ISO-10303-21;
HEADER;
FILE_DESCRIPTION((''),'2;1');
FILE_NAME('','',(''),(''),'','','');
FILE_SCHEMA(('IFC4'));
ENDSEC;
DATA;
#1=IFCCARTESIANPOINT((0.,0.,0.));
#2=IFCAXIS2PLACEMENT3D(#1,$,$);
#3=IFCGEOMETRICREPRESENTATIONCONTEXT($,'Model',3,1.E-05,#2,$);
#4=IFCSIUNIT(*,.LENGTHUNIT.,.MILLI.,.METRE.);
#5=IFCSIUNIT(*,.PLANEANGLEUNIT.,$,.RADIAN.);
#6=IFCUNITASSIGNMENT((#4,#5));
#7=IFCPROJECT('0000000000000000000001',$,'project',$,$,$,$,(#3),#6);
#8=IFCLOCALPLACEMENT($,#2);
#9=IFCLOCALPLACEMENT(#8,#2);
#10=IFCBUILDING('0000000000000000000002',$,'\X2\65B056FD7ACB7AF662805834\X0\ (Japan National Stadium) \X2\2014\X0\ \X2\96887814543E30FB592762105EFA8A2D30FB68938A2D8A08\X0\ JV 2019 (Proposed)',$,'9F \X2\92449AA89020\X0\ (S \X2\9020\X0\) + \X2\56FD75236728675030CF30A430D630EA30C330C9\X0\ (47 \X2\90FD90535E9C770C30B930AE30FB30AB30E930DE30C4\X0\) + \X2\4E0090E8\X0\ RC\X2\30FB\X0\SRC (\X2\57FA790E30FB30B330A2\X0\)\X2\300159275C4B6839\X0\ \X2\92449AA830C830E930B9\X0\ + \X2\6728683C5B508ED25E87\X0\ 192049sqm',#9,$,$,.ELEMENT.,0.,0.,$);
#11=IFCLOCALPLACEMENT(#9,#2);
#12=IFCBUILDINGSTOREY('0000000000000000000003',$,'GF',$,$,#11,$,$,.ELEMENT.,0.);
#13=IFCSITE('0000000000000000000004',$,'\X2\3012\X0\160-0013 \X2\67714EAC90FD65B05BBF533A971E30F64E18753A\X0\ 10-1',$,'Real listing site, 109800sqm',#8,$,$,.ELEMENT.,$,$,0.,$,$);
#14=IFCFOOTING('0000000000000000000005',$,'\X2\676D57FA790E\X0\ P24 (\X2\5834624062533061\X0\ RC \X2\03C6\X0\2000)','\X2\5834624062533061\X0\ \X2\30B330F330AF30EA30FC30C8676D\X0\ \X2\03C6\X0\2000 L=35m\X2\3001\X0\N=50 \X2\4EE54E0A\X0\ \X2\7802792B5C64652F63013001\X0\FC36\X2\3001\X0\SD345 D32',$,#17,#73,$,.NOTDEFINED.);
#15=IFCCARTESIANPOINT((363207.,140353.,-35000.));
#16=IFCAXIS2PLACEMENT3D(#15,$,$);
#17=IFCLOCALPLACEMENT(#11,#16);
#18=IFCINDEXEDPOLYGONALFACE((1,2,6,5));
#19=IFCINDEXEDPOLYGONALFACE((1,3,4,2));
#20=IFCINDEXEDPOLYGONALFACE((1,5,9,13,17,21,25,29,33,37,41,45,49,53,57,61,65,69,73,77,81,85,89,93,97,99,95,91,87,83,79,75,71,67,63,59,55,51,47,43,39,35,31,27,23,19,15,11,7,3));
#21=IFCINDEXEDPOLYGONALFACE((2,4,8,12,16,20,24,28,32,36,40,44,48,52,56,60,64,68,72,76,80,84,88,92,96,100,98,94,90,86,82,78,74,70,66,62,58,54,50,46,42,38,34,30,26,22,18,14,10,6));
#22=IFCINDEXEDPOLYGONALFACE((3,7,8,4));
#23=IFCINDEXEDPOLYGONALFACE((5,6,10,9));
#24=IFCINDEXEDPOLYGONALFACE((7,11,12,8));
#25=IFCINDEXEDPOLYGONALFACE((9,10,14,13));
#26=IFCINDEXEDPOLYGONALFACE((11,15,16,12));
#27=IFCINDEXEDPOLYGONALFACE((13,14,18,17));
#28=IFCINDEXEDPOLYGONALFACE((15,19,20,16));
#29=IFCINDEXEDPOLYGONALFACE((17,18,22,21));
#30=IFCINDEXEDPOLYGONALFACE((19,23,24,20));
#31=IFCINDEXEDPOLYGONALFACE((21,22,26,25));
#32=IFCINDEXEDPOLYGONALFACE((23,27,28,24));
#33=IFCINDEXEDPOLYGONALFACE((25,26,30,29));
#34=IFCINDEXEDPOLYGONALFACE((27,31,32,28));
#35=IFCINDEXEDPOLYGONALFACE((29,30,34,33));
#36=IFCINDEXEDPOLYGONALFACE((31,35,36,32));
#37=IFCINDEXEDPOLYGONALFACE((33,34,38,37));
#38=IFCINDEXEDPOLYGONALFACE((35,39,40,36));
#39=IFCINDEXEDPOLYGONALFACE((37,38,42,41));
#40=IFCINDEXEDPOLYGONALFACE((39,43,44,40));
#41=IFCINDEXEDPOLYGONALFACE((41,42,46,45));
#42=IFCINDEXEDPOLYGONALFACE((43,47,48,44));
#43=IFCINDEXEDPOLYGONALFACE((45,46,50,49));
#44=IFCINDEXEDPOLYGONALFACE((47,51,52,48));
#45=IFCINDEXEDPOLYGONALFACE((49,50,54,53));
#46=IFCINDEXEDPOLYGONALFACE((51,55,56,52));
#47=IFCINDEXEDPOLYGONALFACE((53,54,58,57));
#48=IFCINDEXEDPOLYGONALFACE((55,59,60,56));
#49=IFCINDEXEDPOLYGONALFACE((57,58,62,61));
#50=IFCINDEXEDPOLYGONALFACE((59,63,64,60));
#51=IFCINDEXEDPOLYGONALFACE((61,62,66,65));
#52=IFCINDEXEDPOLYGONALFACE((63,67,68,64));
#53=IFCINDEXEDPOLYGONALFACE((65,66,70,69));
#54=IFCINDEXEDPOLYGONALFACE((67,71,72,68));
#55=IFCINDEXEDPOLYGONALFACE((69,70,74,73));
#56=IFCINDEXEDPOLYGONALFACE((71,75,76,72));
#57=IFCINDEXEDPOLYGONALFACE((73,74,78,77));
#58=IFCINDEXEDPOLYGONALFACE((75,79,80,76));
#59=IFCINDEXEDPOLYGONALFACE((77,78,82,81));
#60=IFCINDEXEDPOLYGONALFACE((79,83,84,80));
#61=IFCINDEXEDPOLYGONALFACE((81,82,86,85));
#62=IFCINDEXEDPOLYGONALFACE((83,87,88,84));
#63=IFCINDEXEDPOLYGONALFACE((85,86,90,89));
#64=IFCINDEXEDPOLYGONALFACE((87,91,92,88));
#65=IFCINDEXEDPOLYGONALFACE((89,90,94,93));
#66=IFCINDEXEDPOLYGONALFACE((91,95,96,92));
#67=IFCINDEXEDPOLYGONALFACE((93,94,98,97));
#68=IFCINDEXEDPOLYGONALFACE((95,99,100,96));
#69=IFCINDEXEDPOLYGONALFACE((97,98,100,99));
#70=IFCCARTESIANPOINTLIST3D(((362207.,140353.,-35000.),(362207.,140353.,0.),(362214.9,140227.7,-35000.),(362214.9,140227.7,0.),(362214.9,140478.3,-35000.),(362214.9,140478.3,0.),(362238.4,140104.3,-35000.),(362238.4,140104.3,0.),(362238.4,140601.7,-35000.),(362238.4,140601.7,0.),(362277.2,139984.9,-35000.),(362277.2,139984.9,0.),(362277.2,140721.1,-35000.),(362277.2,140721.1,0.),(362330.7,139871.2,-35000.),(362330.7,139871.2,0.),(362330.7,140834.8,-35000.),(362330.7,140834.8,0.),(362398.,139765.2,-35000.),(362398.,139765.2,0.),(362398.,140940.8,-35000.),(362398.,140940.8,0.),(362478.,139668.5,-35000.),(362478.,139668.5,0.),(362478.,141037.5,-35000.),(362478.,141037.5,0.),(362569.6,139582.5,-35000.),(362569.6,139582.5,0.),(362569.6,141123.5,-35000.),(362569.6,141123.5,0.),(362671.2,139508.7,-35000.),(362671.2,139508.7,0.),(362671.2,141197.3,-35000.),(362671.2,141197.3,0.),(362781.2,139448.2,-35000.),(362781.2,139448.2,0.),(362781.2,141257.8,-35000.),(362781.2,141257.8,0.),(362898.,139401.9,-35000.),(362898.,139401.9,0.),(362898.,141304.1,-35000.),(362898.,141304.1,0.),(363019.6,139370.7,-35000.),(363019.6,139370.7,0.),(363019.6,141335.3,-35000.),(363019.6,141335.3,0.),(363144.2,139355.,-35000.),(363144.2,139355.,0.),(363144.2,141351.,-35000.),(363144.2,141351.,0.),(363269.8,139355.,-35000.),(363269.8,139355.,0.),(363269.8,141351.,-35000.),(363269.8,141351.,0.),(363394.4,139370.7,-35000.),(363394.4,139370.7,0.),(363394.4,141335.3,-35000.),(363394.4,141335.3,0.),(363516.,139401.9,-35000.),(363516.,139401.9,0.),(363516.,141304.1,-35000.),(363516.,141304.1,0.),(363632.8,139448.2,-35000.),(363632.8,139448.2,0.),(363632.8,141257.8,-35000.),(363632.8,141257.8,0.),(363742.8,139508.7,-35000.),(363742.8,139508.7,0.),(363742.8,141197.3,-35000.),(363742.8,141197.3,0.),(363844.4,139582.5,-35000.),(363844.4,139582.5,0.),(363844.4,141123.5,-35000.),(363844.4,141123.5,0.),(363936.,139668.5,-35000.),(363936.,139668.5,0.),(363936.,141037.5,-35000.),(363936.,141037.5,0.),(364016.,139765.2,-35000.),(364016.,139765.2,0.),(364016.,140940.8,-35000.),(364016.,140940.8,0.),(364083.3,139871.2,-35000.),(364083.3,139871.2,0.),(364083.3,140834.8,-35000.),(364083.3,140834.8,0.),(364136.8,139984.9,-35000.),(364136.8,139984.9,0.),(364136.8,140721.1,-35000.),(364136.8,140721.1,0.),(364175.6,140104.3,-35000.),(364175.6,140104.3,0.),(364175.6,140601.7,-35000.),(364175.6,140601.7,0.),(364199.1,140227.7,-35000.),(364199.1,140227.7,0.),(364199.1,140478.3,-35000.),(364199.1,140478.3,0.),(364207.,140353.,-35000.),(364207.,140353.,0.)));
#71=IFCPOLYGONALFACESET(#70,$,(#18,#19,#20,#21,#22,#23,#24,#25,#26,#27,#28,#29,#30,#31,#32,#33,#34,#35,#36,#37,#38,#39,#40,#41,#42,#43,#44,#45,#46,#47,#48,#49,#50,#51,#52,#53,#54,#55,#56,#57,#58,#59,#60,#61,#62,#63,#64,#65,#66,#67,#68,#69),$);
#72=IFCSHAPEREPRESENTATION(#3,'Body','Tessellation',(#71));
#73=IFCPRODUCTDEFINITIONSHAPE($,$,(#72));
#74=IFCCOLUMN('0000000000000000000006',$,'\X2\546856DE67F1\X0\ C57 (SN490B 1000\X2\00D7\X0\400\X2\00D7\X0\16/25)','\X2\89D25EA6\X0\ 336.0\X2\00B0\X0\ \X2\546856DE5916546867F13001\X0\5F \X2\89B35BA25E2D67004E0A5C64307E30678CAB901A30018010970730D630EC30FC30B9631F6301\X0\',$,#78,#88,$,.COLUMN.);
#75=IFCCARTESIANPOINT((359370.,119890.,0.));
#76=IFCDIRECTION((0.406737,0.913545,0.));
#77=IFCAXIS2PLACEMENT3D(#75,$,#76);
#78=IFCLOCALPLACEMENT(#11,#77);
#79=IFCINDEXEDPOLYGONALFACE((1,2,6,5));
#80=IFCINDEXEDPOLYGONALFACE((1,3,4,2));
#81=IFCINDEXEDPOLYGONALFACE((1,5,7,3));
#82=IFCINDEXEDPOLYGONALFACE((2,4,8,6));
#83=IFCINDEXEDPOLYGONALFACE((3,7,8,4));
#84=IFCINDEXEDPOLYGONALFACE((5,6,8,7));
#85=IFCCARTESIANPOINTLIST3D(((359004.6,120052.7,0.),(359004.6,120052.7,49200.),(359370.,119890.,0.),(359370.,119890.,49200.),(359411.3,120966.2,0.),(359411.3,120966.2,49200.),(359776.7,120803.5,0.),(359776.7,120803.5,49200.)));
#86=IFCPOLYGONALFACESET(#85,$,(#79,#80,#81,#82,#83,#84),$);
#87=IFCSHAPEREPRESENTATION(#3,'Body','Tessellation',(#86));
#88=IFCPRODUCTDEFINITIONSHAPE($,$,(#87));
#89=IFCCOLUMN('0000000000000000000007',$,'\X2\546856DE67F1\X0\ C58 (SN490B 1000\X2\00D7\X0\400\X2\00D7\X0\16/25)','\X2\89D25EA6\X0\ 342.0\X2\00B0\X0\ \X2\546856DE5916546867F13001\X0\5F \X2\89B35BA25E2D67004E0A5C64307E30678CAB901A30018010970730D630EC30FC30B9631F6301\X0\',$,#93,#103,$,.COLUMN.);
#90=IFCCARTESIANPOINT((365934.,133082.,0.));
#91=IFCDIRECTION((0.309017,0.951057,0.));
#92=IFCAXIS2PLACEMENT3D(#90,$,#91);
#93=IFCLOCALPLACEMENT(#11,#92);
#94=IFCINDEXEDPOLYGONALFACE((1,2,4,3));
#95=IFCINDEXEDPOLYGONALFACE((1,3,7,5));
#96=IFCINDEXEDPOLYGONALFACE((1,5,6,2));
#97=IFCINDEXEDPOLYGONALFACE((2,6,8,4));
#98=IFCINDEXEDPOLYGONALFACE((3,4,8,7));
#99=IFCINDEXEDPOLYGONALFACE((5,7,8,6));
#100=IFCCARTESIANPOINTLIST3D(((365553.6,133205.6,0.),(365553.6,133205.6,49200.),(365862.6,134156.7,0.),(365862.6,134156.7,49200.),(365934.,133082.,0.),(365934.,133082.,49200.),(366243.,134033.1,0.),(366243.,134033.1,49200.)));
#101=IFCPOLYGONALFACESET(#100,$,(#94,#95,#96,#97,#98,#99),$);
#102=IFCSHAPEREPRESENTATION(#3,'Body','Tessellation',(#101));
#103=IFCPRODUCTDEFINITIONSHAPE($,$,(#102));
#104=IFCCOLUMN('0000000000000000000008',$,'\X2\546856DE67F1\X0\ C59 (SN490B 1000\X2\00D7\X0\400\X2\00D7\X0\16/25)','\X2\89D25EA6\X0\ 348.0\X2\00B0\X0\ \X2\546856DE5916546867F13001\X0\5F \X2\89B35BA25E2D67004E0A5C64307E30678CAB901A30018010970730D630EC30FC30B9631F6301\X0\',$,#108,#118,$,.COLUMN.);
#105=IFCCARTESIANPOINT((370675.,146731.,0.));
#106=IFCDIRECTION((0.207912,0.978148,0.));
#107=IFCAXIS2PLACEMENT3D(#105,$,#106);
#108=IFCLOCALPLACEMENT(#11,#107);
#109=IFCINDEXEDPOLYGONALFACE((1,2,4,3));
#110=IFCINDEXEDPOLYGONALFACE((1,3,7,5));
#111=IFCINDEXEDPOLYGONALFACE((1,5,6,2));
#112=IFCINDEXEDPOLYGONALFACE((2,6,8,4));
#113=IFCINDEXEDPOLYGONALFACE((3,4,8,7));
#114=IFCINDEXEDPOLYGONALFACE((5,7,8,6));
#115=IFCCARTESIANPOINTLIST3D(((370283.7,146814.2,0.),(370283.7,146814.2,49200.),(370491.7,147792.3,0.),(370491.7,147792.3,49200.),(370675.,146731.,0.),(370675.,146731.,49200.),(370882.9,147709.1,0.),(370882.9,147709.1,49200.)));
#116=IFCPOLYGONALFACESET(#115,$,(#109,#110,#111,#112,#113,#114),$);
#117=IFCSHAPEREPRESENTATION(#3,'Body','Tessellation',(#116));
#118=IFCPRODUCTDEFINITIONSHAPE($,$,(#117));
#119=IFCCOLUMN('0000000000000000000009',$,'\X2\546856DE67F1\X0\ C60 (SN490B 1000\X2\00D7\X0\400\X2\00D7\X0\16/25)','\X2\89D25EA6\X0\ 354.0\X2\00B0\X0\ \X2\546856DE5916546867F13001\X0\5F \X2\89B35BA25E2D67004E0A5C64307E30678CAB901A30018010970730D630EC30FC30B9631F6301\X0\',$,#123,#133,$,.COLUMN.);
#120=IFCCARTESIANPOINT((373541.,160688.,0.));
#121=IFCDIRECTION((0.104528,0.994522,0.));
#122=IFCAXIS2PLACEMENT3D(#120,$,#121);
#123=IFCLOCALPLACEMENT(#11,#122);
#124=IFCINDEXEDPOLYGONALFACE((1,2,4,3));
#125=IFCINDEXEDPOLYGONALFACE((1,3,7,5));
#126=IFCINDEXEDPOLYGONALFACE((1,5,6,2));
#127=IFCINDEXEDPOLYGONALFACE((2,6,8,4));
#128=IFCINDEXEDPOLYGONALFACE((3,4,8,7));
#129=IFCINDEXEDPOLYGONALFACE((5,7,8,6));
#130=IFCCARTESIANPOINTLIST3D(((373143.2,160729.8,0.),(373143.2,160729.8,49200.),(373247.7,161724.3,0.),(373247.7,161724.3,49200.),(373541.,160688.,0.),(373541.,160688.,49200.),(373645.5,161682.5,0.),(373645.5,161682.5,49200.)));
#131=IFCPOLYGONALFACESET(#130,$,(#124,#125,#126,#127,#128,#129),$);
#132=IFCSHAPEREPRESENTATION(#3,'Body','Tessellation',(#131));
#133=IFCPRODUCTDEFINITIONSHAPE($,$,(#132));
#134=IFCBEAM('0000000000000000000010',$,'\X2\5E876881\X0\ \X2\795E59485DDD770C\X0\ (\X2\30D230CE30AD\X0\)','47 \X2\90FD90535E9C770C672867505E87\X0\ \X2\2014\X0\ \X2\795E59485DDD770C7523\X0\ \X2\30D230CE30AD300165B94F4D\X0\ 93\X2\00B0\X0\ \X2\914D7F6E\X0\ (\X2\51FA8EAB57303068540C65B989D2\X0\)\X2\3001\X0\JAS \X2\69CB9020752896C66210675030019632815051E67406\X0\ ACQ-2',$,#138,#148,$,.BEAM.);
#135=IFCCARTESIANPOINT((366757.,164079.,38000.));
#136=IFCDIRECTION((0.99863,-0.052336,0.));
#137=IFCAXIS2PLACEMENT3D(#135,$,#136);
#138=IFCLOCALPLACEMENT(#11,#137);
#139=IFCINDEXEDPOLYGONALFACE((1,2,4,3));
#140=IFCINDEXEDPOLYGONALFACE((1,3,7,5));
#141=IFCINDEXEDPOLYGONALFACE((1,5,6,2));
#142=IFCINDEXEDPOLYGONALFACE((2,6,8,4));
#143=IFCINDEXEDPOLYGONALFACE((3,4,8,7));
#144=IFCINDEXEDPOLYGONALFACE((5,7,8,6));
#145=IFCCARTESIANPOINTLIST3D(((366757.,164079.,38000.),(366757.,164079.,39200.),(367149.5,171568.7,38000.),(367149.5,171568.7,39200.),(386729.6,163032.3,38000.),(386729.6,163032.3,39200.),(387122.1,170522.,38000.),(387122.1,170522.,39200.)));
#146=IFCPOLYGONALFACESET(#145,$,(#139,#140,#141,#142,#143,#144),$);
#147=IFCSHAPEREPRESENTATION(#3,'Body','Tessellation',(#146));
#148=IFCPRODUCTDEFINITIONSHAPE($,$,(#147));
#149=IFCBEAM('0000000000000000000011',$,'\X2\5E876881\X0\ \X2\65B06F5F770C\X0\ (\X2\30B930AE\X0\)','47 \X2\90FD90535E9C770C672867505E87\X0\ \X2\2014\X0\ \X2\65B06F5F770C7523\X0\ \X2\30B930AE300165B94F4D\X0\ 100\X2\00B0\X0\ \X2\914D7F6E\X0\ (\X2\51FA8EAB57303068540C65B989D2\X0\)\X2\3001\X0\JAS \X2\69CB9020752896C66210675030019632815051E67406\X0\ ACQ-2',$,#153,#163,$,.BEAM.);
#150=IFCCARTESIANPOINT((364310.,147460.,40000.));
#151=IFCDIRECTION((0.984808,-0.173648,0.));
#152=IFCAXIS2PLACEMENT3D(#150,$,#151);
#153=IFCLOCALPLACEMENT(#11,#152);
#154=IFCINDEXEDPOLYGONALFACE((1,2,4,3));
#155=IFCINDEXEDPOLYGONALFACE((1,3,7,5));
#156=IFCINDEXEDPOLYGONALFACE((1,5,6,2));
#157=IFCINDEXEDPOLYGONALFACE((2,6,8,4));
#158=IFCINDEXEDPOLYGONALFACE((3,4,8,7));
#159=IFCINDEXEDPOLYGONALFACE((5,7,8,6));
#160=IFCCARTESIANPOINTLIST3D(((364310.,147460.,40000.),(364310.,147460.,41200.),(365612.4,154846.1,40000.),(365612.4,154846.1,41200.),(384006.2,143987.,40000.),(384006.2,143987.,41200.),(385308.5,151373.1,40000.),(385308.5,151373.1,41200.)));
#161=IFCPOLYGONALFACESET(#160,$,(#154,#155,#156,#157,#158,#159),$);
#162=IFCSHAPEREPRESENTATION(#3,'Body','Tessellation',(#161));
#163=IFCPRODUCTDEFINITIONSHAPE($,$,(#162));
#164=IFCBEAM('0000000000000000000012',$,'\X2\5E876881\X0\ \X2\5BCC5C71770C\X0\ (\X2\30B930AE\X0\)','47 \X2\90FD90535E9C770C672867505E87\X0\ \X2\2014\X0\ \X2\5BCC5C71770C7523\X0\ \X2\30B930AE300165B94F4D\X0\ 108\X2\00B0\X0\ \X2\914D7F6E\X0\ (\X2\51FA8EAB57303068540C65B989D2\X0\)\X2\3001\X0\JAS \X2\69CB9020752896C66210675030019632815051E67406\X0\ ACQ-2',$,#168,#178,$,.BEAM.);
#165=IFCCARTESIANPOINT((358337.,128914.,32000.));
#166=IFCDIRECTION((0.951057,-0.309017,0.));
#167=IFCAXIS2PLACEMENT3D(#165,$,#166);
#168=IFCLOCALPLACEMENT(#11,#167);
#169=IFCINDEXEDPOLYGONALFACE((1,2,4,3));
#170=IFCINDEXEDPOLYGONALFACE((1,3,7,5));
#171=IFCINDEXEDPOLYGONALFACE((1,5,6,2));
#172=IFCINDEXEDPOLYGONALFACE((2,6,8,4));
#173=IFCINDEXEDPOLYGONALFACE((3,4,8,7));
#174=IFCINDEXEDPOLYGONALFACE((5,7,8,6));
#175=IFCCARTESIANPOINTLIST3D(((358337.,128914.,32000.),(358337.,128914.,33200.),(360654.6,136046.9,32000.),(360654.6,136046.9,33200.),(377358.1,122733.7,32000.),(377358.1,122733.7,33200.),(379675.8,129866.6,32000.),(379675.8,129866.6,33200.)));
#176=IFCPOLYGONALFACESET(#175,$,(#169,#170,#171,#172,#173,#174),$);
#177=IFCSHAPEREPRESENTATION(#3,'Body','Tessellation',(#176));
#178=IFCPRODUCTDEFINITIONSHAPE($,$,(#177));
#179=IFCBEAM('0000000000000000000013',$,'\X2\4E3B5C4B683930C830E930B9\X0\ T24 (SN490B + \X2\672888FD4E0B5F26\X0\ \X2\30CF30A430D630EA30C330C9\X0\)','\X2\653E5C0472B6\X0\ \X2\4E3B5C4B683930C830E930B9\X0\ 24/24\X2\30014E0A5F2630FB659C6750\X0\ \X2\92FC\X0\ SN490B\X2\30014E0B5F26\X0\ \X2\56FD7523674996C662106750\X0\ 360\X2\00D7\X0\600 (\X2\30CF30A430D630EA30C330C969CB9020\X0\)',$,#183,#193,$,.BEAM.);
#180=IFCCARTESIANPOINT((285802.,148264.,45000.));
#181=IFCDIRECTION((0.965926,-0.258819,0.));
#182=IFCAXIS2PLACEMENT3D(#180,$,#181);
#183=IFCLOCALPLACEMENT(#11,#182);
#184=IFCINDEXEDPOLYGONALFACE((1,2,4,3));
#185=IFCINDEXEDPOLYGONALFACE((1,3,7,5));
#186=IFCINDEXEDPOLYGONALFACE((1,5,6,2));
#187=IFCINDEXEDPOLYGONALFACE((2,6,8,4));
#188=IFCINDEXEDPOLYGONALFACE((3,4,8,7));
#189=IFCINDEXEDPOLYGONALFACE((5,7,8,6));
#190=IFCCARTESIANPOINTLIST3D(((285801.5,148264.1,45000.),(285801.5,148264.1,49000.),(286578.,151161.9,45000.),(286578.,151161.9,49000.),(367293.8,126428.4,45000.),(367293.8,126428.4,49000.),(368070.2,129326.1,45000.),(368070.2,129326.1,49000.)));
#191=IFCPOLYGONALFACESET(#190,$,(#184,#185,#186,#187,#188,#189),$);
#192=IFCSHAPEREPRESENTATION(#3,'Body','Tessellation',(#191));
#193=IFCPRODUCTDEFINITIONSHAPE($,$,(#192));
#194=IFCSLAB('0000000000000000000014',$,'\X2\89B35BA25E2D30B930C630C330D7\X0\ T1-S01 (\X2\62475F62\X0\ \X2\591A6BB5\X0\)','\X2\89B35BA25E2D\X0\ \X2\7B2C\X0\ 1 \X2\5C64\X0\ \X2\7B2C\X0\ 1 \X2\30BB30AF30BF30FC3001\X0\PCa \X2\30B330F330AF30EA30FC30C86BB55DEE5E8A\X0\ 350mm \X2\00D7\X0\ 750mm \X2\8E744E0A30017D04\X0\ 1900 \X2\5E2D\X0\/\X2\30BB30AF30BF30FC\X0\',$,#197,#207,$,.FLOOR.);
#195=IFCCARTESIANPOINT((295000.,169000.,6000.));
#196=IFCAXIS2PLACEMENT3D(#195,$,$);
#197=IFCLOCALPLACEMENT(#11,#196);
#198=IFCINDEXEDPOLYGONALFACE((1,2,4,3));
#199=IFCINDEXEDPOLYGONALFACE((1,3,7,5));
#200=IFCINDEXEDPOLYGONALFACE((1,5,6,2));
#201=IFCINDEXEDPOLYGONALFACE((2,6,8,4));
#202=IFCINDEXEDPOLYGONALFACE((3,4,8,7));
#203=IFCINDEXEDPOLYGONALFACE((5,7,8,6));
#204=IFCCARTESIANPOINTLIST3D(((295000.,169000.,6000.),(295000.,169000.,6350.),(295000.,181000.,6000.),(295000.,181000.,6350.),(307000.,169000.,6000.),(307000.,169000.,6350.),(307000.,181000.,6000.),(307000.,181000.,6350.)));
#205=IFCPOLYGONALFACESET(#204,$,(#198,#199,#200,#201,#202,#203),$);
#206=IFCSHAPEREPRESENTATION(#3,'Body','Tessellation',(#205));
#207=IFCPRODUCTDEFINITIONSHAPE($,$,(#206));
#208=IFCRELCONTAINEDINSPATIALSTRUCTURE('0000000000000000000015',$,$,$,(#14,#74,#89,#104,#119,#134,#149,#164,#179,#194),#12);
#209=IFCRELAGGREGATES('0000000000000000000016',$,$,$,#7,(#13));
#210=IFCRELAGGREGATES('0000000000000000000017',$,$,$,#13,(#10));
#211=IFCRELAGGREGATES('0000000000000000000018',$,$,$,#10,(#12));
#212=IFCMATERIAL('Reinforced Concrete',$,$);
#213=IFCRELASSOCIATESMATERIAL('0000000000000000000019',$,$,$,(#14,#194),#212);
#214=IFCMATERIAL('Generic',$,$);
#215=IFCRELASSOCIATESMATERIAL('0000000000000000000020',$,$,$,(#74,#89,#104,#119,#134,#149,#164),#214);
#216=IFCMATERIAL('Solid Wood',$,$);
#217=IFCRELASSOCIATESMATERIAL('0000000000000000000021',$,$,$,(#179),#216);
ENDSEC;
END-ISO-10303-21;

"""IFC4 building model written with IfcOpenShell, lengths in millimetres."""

from ifc_helpers import new_model, si_unit, frame, frame_2d, origin, origin_2d, place, context, project, spatial, rectangle, circle, extrude, material, element, save


model = new_model("IFC4")

# Units and contexts
model_context = context("Model", 3, precision=1e-05, world=origin())
ifc_project = project(units=[si_unit("LENGTHUNIT", "METRE", prefix="MILLI"), si_unit("PLANEANGLEUNIT", "RADIAN")], contexts=[model_context])

# Site, building, storey
site_placement = place(None, origin())
site = spatial("IfcSite", under=ifc_project, at=site_placement, Name="〒160-0013 東京都新宿区霞ヶ丘町 10-1", ObjectType="Real listing site, 109800sqm", CompositionType="ELEMENT", RefElevation=0.0)
building_placement = place(site_placement, origin())
building = spatial("IfcBuilding", under=site, at=building_placement, Name="新国立競技場 (Japan National Stadium) — 隈研吾・大成建設・梓設計 JV 2019 (Proposed)", ObjectType="9F 鉄骨造 (S 造) + 国産木材ハイブリッド (47 都道府県スギ・カラマツ) + 一部 RC・SRC (基礎・コア)、大屋根 鉄骨トラス + 木格子軒庇 192049sqm", CompositionType="ELEMENT", ElevationOfRefHeight=0.0, ElevationOfTerrain=0.0)
storey_placement = place(building_placement, origin())
storey = spatial("IfcBuildingStorey", under=building, at=storey_placement, Name="GF", CompositionType="ELEMENT", Elevation=0.0)

# Footing
ifc_material_1 = material(Name="Reinforced Concrete")
footing_placement = place(storey_placement, frame((363207.0, 140353.0, -35000.0)))
element("IfcFooting", 1, at=footing_placement, inside=storey, material=ifc_material_1, Name="杭基礎 P24 (場所打ち RC φ2000)", Description="場所打ち コンクリート杭 φ2000 L=35m、N=50 以上 砂礫層支持、FC36、SD345 D32", PredefinedType="NOTDEFINED", context=model_context, shape_type="SweptSolid", body=[
    extrude(circle(Radius=1000.0, at=origin_2d()), frame((363207.0, 140353.0, -35000.0)), (0.0, 0.0, 1.0), 35000.0),
])

# Columns
ifc_material_2 = material(Name="Generic")
column_1_placement = place(storey_placement, frame((359370.0, 119890.0, 0.0), x_axis=(0.406737, 0.913545, 0.0)))
element("IfcColumn", 2, at=column_1_placement, inside=storey, material=ifc_material_2, Name="周回柱 C57 (SN490B 1000×400×16/25)", Description="角度 336.0° 周回外周柱、5F 観客席最上層まで貫通、耐震ブレース挟持", PredefinedType="COLUMN", context=model_context, shape_type="SweptSolid", body=[
    extrude(rectangle(XDim=1000.0, YDim=400.0, at=frame_2d((500.0, 200.0))), frame((359370.0, 119890.0, 0.0), x_axis=(0.406737, 0.913545, 0.0)), (0.0, 0.0, 1.0), 49200.0),
])
column_2_placement = place(storey_placement, frame((365934.0, 133082.0, 0.0), x_axis=(0.309017, 0.951057, 0.0)))
element("IfcColumn", 3, at=column_2_placement, inside=storey, material=ifc_material_2, Name="周回柱 C58 (SN490B 1000×400×16/25)", Description="角度 342.0° 周回外周柱、5F 観客席最上層まで貫通、耐震ブレース挟持", PredefinedType="COLUMN", context=model_context, shape_type="SweptSolid", body=[
    extrude(rectangle(XDim=1000.0, YDim=400.0, at=frame_2d((500.0, 200.0))), frame((365934.0, 133082.0, 0.0), x_axis=(0.309017, 0.951057, 0.0)), (0.0, 0.0, 1.0), 49200.0),
])
column_3_placement = place(storey_placement, frame((370675.0, 146731.0, 0.0), x_axis=(0.207912, 0.978148, 0.0)))
element("IfcColumn", 4, at=column_3_placement, inside=storey, material=ifc_material_2, Name="周回柱 C59 (SN490B 1000×400×16/25)", Description="角度 348.0° 周回外周柱、5F 観客席最上層まで貫通、耐震ブレース挟持", PredefinedType="COLUMN", context=model_context, shape_type="SweptSolid", body=[
    extrude(rectangle(XDim=1000.0, YDim=400.0, at=frame_2d((500.0, 200.0))), frame((370675.0, 146731.0, 0.0), x_axis=(0.207912, 0.978148, 0.0)), (0.0, 0.0, 1.0), 49200.0),
])
column_4_placement = place(storey_placement, frame((373541.0, 160688.0, 0.0), x_axis=(0.104528, 0.994522, 0.0)))
element("IfcColumn", 5, at=column_4_placement, inside=storey, material=ifc_material_2, Name="周回柱 C60 (SN490B 1000×400×16/25)", Description="角度 354.0° 周回外周柱、5F 観客席最上層まで貫通、耐震ブレース挟持", PredefinedType="COLUMN", context=model_context, shape_type="SweptSolid", body=[
    extrude(rectangle(XDim=1000.0, YDim=400.0, at=frame_2d((500.0, 200.0))), frame((373541.0, 160688.0, 0.0), x_axis=(0.104528, 0.994522, 0.0)), (0.0, 0.0, 1.0), 49200.0),
])

# Beams
beam_1_placement = place(storey_placement, frame((366757.0, 164079.0, 38000.0), x_axis=(0.99863, -0.052336, 0.0)))
element("IfcBeam", 6, at=beam_1_placement, inside=storey, material=ifc_material_2, Name="庇梁 神奈川県 (ヒノキ)", Description="47 都道府県木材庇 — 神奈川県産 ヒノキ、方位 93° 配置 (出身地と同方角)、JAS 構造用集成材、防腐処理 ACQ-2", PredefinedType="BEAM", context=model_context, shape_type="SweptSolid", body=[
    extrude(rectangle(XDim=20000.0, YDim=7500.0, at=frame_2d((10000.0, 3750.0))), frame((366757.0, 164079.0, 38000.0), x_axis=(0.99863, -0.052336, 0.0)), (0.0, 0.0, 1.0), 1200.0),
])
beam_2_placement = place(storey_placement, frame((364310.0, 147460.0, 40000.0), x_axis=(0.984808, -0.173648, 0.0)))
element("IfcBeam", 7, at=beam_2_placement, inside=storey, material=ifc_material_2, Name="庇梁 新潟県 (スギ)", Description="47 都道府県木材庇 — 新潟県産 スギ、方位 100° 配置 (出身地と同方角)、JAS 構造用集成材、防腐処理 ACQ-2", PredefinedType="BEAM", context=model_context, shape_type="SweptSolid", body=[
    extrude(rectangle(XDim=20000.0, YDim=7500.0, at=frame_2d((10000.0, 3750.0))), frame((364310.0, 147460.0, 40000.0), x_axis=(0.984808, -0.173648, 0.0)), (0.0, 0.0, 1.0), 1200.0),
])
beam_3_placement = place(storey_placement, frame((358337.0, 128914.0, 32000.0), x_axis=(0.951057, -0.309017, 0.0)))
element("IfcBeam", 8, at=beam_3_placement, inside=storey, material=ifc_material_2, Name="庇梁 富山県 (スギ)", Description="47 都道府県木材庇 — 富山県産 スギ、方位 108° 配置 (出身地と同方角)、JAS 構造用集成材、防腐処理 ACQ-2", PredefinedType="BEAM", context=model_context, shape_type="SweptSolid", body=[
    extrude(rectangle(XDim=20000.0, YDim=7500.0, at=frame_2d((10000.0, 3750.0))), frame((358337.0, 128914.0, 32000.0), x_axis=(0.951057, -0.309017, 0.0)), (0.0, 0.0, 1.0), 1200.0),
])
ifc_material_3 = material(Name="Solid Wood")
beam_4_placement = place(storey_placement, frame((285802.0, 148264.0, 45000.0), x_axis=(0.965926, -0.258819, 0.0)))
element("IfcBeam", 9, at=beam_4_placement, inside=storey, material=ifc_material_3, Name="主屋根トラス T24 (SN490B + 木製下弦 ハイブリッド)", Description="放射状 主屋根トラス 24/24、上弦・斜材 鋼 SN490B、下弦 国産杉集成材 360×600 (ハイブリッド構造)", PredefinedType="BEAM", context=model_context, shape_type="SweptSolid", body=[
    extrude(rectangle(XDim=84367.0, YDim=3000.0, at=frame_2d((42183.0, 1500.0))), frame((285802.0, 148264.0, 45000.0), x_axis=(0.965926, -0.258819, 0.0)), (0.0, 0.0, 1.0), 4000.0),
])

# Slab
slab_1_placement = place(storey_placement, frame((295000.0, 169000.0, 6000.0)))
element("IfcSlab", 10, at=slab_1_placement, inside=storey, material=ifc_material_1, Name="観客席ステップ T1-S01 (扇形 多段)", Description="観客席 第 1 層 第 1 セクター、PCa コンクリート段差床 350mm × 750mm 蹴上、約 1900 席/セクター", PredefinedType="FLOOR", context=model_context, shape_type="SweptSolid", body=[
    extrude(rectangle(XDim=12000.0, YDim=12000.0, at=frame_2d((6000.0, 6000.0))), frame((295000.0, 169000.0, 6000.0)), (0.0, 0.0, 1.0), 350.0),
])

save(model, "model.ifc")
